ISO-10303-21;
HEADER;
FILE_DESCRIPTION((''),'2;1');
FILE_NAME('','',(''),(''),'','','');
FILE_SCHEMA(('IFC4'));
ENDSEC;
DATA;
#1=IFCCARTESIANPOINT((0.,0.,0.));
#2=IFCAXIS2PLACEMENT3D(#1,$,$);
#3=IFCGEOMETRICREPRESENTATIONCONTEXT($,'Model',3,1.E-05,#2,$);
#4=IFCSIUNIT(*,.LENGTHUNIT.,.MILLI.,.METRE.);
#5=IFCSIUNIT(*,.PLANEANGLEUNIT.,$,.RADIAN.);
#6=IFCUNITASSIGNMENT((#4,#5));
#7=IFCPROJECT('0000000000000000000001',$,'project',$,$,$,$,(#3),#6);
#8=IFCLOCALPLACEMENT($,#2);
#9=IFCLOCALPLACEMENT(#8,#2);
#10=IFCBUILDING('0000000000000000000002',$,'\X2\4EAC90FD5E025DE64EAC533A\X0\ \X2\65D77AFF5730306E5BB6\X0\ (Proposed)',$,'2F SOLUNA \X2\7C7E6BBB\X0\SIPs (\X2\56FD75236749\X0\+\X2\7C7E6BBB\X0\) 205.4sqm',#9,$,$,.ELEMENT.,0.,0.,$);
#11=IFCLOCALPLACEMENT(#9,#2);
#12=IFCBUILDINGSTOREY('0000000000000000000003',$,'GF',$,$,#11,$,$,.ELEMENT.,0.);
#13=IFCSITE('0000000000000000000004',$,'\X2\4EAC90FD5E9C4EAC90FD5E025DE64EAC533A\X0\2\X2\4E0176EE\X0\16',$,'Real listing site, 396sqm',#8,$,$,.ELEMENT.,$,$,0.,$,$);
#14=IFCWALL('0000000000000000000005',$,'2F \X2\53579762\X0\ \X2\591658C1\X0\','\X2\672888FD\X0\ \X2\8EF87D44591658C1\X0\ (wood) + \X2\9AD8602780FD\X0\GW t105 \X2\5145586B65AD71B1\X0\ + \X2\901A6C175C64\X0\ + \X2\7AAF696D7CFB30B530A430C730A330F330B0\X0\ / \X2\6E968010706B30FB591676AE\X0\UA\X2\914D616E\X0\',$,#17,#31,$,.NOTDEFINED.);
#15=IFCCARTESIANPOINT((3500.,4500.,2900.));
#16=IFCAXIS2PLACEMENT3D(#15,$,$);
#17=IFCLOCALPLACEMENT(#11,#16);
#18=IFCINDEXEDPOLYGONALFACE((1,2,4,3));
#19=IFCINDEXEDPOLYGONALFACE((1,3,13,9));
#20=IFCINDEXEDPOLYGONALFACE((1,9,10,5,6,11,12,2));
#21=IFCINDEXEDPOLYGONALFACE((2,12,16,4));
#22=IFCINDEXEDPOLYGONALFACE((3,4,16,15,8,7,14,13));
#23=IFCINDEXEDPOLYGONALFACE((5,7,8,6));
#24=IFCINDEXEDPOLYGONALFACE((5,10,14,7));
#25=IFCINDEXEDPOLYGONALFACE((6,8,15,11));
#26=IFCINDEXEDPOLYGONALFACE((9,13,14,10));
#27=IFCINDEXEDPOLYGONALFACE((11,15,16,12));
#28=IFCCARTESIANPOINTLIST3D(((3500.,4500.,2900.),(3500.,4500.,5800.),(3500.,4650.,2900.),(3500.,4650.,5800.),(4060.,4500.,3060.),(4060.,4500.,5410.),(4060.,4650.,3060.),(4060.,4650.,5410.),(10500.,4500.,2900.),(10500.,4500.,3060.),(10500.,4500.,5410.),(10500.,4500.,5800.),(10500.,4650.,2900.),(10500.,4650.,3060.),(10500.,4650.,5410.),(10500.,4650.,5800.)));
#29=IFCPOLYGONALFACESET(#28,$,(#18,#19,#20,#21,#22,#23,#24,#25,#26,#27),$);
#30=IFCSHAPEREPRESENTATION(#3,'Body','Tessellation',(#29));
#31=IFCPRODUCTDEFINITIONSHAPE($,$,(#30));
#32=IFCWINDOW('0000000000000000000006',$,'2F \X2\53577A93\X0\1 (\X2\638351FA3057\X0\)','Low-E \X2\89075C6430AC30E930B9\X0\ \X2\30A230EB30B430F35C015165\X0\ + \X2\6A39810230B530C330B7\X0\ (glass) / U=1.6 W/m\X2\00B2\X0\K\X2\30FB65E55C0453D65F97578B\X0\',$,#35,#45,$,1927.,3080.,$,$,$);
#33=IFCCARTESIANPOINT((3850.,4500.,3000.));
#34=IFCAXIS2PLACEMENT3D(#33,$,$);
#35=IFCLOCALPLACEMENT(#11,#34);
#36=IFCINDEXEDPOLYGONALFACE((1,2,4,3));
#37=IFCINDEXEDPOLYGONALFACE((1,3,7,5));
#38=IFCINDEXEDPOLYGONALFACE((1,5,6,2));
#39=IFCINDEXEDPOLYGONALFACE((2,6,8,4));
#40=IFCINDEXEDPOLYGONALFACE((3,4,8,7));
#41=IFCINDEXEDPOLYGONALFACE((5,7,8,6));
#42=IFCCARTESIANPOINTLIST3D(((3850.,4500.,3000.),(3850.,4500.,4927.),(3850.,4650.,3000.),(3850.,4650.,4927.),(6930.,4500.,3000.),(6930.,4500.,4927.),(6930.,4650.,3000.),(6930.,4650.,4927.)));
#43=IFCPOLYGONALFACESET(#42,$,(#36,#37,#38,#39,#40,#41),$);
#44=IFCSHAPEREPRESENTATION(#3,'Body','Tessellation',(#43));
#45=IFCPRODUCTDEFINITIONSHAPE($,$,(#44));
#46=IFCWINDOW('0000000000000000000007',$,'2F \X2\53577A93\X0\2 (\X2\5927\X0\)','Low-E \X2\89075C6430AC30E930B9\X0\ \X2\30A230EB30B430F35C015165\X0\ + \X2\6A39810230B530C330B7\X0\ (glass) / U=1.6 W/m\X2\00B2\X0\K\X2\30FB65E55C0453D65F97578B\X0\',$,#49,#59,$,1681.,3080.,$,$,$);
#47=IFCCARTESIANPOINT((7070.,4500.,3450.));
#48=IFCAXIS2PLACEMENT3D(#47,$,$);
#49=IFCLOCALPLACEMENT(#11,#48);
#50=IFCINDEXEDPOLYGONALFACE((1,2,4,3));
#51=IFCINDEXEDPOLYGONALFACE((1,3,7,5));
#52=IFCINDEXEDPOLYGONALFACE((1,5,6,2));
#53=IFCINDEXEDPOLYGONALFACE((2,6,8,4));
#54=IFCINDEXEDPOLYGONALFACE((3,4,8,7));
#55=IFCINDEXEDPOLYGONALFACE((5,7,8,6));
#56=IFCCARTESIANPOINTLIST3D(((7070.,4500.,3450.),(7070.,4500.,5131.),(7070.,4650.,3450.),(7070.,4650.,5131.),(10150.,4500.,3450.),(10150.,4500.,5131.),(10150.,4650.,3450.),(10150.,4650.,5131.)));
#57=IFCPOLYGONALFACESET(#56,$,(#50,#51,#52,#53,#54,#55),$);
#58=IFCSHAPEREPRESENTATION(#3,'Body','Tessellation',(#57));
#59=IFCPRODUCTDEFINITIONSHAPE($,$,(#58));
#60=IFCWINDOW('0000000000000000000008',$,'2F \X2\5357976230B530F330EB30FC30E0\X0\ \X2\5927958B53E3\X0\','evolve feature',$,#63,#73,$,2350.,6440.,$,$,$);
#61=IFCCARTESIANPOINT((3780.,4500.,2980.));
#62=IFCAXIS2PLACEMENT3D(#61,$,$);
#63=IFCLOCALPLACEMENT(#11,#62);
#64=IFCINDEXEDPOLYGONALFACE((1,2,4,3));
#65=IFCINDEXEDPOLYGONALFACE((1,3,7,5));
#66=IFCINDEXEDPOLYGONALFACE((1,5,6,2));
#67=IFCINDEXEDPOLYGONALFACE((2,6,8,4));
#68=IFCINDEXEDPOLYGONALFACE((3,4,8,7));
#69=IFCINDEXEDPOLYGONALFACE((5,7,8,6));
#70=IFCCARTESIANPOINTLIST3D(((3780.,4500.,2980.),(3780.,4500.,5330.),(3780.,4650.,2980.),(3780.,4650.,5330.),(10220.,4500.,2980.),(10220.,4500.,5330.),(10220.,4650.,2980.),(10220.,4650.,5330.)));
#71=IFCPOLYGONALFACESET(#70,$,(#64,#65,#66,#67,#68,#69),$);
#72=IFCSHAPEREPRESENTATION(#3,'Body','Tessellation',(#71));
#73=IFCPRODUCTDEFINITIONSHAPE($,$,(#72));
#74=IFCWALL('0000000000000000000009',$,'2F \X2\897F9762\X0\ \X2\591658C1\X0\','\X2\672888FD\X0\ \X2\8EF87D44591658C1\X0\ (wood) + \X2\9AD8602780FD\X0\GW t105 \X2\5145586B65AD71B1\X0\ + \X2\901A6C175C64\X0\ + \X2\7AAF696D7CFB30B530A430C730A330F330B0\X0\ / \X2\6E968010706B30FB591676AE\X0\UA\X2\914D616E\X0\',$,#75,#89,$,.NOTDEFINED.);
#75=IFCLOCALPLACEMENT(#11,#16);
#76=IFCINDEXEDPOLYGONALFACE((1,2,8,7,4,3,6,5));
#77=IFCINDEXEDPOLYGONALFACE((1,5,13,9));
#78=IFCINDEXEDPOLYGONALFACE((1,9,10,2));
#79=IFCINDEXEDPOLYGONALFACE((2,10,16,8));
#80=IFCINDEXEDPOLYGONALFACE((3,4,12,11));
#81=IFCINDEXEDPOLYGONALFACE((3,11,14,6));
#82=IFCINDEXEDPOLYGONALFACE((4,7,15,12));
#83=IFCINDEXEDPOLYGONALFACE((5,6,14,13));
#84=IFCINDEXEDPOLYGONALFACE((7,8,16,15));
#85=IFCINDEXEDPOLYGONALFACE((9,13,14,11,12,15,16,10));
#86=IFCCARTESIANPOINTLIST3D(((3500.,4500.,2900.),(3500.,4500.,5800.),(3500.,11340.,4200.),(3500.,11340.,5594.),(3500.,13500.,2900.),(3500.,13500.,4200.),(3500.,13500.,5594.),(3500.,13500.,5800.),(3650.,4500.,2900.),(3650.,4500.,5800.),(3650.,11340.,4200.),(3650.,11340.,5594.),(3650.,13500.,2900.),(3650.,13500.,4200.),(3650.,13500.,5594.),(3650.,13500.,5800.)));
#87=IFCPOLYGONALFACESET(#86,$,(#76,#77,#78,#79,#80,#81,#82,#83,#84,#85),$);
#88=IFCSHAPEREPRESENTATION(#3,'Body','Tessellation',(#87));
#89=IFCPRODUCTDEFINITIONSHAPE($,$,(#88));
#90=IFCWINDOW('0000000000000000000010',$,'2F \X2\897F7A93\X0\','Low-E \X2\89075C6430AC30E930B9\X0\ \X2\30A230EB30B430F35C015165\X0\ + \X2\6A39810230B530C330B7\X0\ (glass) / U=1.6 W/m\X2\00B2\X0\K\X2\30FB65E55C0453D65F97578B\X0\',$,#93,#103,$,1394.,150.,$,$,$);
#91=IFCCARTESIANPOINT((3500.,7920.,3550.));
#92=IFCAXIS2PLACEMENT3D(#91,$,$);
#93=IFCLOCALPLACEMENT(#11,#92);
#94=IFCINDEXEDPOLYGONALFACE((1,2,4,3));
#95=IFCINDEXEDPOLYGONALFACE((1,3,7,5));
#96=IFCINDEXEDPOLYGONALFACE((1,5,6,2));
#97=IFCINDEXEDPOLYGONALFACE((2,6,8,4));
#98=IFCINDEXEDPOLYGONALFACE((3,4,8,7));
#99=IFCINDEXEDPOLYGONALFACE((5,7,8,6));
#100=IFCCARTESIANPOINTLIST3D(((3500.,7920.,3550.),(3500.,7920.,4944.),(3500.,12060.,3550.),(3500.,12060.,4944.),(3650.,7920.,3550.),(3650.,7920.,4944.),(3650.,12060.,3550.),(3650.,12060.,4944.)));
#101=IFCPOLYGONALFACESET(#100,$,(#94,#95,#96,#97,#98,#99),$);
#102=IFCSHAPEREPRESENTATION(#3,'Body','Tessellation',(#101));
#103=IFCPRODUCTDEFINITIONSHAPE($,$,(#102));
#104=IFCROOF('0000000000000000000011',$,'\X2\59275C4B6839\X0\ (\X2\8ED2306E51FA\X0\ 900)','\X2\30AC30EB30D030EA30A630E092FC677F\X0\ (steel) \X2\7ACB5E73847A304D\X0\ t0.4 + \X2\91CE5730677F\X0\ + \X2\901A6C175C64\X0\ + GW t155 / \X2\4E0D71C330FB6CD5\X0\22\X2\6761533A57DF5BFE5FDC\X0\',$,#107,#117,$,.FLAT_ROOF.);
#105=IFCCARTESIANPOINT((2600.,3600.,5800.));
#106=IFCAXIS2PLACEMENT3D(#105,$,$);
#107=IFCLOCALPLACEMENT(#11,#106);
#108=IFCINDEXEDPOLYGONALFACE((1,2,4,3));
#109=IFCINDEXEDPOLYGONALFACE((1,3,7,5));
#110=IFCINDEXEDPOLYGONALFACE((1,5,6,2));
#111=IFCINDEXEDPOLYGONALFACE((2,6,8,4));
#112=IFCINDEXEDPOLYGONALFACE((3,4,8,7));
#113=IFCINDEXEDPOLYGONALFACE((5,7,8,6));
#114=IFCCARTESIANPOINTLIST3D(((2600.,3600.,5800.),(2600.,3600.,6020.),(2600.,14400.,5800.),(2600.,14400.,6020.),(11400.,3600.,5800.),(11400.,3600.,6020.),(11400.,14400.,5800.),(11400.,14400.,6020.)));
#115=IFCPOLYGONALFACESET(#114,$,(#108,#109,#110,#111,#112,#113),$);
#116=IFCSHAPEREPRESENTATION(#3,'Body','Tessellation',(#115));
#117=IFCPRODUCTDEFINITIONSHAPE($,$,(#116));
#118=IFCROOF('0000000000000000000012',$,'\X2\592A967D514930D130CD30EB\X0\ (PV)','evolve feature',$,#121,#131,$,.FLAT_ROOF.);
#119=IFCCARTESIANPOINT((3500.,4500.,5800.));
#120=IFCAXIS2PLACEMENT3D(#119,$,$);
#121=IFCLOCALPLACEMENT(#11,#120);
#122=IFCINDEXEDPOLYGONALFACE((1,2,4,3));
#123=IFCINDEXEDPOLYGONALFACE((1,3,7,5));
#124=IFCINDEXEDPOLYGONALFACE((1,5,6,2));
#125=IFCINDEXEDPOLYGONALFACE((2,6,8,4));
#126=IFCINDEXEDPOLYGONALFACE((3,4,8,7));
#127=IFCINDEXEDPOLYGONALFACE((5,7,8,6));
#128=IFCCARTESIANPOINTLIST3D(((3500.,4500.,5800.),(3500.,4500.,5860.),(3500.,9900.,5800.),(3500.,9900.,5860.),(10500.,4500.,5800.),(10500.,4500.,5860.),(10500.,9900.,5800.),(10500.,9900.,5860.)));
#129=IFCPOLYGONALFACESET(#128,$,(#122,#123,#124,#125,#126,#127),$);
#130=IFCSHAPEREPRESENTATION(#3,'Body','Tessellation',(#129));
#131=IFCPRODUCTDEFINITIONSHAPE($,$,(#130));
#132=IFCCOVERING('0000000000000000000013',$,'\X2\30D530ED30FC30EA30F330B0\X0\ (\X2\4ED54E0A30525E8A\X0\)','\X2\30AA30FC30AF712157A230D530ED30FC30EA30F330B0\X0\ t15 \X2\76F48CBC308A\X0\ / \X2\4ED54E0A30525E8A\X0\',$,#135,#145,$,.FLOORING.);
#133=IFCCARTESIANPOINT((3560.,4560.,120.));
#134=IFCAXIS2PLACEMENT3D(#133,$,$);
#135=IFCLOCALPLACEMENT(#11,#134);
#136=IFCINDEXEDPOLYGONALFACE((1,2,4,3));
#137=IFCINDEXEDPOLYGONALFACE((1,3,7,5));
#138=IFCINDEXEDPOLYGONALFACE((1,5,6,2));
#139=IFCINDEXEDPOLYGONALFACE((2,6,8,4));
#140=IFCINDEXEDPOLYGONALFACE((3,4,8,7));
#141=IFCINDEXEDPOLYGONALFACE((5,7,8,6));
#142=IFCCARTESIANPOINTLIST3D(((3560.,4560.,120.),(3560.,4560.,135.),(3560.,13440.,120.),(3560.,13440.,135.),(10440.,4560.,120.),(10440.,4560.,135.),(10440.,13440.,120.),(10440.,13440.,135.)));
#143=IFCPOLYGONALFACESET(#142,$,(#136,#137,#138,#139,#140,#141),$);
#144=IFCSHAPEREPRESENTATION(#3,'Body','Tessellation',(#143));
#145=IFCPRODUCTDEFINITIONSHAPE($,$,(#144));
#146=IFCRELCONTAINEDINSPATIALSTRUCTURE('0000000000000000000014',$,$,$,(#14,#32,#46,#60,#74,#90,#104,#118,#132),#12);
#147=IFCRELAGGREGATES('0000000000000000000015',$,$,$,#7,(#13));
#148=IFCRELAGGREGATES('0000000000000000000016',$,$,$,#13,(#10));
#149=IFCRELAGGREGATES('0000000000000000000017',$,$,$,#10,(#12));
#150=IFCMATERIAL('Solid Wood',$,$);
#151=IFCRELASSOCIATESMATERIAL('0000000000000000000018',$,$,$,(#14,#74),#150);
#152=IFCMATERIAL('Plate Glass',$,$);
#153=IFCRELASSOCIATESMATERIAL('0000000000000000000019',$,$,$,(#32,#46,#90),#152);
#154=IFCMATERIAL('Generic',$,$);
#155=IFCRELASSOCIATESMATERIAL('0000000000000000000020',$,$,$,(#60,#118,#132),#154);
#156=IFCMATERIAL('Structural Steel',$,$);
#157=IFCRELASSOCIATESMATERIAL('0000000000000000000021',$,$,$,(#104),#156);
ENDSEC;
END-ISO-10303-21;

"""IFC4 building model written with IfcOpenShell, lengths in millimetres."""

from ifc_helpers import new_model, si_unit, frame, frame_2d, origin, place, context, project, spatial, rectangle, extrude, material, element, fill, save


model = new_model("IFC4")

# Units and contexts
model_context = context("Model", 3, precision=1e-05, world=origin())
ifc_project = project(units=[si_unit("LENGTHUNIT", "METRE", prefix="MILLI"), si_unit("PLANEANGLEUNIT", "RADIAN")], contexts=[model_context])

# Site, building, storey
site_placement = place(None, origin())
site = spatial("IfcSite", under=ifc_project, at=site_placement, Name="京都府京都市左京区2丁目16", ObjectType="Real listing site, 396sqm", CompositionType="ELEMENT", RefElevation=0.0)
building_placement = place(site_placement, origin())
building = spatial("IfcBuilding", under=site, at=building_placement, Name="京都市左京区 旗竿地の家 (Proposed)", ObjectType="2F SOLUNA 籾殻SIPs (国産杉+籾殻) 205.4sqm", CompositionType="ELEMENT", ElevationOfRefHeight=0.0, ElevationOfTerrain=0.0)
storey_placement = place(building_placement, origin())
storey = spatial("IfcBuildingStorey", under=building, at=storey_placement, Name="GF", CompositionType="ELEMENT", Elevation=0.0)

# Shared definitions
ifc_material_1 = material(Name="Solid Wood")

# Shared definitions
ifc_material_2 = material(Name="Plate Glass")
ifc_material_3 = material(Name="Generic")

# Wall, openings, windows
wall_1_placement = place(storey_placement, frame((3500.0, 4500.0, 2900.0)))
wall_1 = element("IfcWall", 1, at=wall_1_placement, inside=storey, material=ifc_material_1, Name="2F 南面 外壁", Description="木製 軸組外壁 (wood) + 高性能GW t105 充填断熱 + 通気層 + 窯業系サイディング / 準耐火・外皮UA配慮", PredefinedType="NOTDEFINED", context=model_context, shape_type="SweptSolid", body=[
    extrude(rectangle(XDim=7000.0, YDim=150.0, at=frame_2d((3500.0, 75.0))), frame((3500.0, 4500.0, 2900.0)), (0.0, 0.0, 1.0), 2900.0),
])
opening_1_placement = place(storey_placement, frame((3850.0, 4500.0, 3000.0)))
opening_1 = element("IfcOpeningElement", 2, at=opening_1_placement, cuts=wall_1, PredefinedType="NOTDEFINED", context=model_context, shape_type="SweptSolid", body=[
    extrude(rectangle(XDim=3080.0, YDim=150.0, at=frame_2d((1540.0, 75.0))), frame((3850.0, 4500.0, 3000.0)), (0.0, 0.0, 1.0), 1927.0),
])
opening_2_placement = place(storey_placement, frame((7070.0, 4500.0, 3450.0)))
opening_2 = element("IfcOpeningElement", 3, at=opening_2_placement, cuts=wall_1, PredefinedType="NOTDEFINED", context=model_context, shape_type="SweptSolid", body=[
    extrude(rectangle(XDim=3080.0, YDim=150.0, at=frame_2d((1540.0, 75.0))), frame((7070.0, 4500.0, 3450.0)), (0.0, 0.0, 1.0), 1681.0),
])
opening_3_placement = place(storey_placement, frame((3780.0, 4500.0, 2980.0)))
opening_3 = element("IfcOpeningElement", 4, at=opening_3_placement, cuts=wall_1, PredefinedType="NOTDEFINED", context=model_context, shape_type="SweptSolid", body=[
    extrude(rectangle(XDim=6440.0, YDim=150.0, at=frame_2d((3220.0, 75.0))), frame((3780.0, 4500.0, 2980.0)), (0.0, 0.0, 1.0), 2350.0),
])
window_1_placement = place(storey_placement, frame((3850.0, 4500.0, 3000.0)))
window_1 = element("IfcWindow", 5, at=window_1_placement, inside=storey, material=ifc_material_2, Name="2F 南窓1 (掃出し)", Description="Low-E 複層ガラス アルゴン封入 + 樹脂サッシ (glass) / U=1.6 W/m²K・日射取得型", OverallHeight=1927.0, OverallWidth=3080.0, context=model_context, shape_type="SweptSolid", body=[
    extrude(rectangle(XDim=3080.0, YDim=150.0, at=frame_2d((1540.0, 75.0))), frame((3850.0, 4500.0, 3000.0)), (0.0, 0.0, 1.0), 1927.0),
])
fill(opening_1, window_1)
window_2_placement = place(storey_placement, frame((7070.0, 4500.0, 3450.0)))
window_2 = element("IfcWindow", 6, at=window_2_placement, inside=storey, material=ifc_material_2, Name="2F 南窓2 (大)", Description="Low-E 複層ガラス アルゴン封入 + 樹脂サッシ (glass) / U=1.6 W/m²K・日射取得型", OverallHeight=1681.0, OverallWidth=3080.0, context=model_context, shape_type="SweptSolid", body=[
    extrude(rectangle(XDim=3080.0, YDim=150.0, at=frame_2d((1540.0, 75.0))), frame((7070.0, 4500.0, 3450.0)), (0.0, 0.0, 1.0), 1681.0),
])
fill(opening_2, window_2)
window_3_placement = place(storey_placement, frame((3780.0, 4500.0, 2980.0)))
window_3 = element("IfcWindow", 7, at=window_3_placement, inside=storey, material=ifc_material_3, Name="2F 南面サンルーム 大開口", Description="evolve feature", OverallHeight=2350.0, OverallWidth=6440.0, context=model_context, shape_type="SweptSolid", body=[
    extrude(rectangle(XDim=6440.0, YDim=150.0, at=frame_2d((3220.0, 75.0))), frame((3780.0, 4500.0, 2980.0)), (0.0, 0.0, 1.0), 2350.0),
])
fill(opening_3, window_3)

# Wall, opening, window
wall_2_placement = place(storey_placement, frame((3500.0, 4500.0, 2900.0)))
wall_2 = element("IfcWall", 8, at=wall_2_placement, inside=storey, material=ifc_material_1, Name="2F 西面 外壁", Description="木製 軸組外壁 (wood) + 高性能GW t105 充填断熱 + 通気層 + 窯業系サイディング / 準耐火・外皮UA配慮", PredefinedType="NOTDEFINED", context=model_context, shape_type="SweptSolid", body=[
    extrude(rectangle(XDim=150.0, YDim=9000.0, at=frame_2d((75.0, 4500.0))), frame((3500.0, 4500.0, 2900.0)), (0.0, 0.0, 1.0), 2900.0),
])
opening_4_placement = place(storey_placement, frame((3500.0, 7920.0, 3550.0)))
opening_4 = element("IfcOpeningElement", 9, at=opening_4_placement, cuts=wall_2, PredefinedType="NOTDEFINED", context=model_context, shape_type="SweptSolid", body=[
    extrude(rectangle(XDim=150.0, YDim=4140.0, at=frame_2d((75.0, 2070.0))), frame((3500.0, 7920.0, 3550.0)), (0.0, 0.0, 1.0), 1394.0),
])
window_4_placement = place(storey_placement, frame((3500.0, 7920.0, 3550.0)))
window_4 = element("IfcWindow", 10, at=window_4_placement, inside=storey, material=ifc_material_2, Name="2F 西窓", Description="Low-E 複層ガラス アルゴン封入 + 樹脂サッシ (glass) / U=1.6 W/m²K・日射取得型", OverallHeight=1394.0, OverallWidth=150.0, context=model_context, shape_type="SweptSolid", body=[
    extrude(rectangle(XDim=150.0, YDim=4140.0, at=frame_2d((75.0, 2070.0))), frame((3500.0, 7920.0, 3550.0)), (0.0, 0.0, 1.0), 1394.0),
])
fill(opening_4, window_4)

# Roofs
ifc_material_4 = material(Name="Structural Steel")
roof_1_placement = place(storey_placement, frame((2600.0, 3600.0, 5800.0)))
element("IfcRoof", 11, at=roof_1_placement, inside=storey, material=ifc_material_4, Name="大屋根 (軒の出 900)", Description="ガルバリウム鋼板 (steel) 立平葺き t0.4 + 野地板 + 通気層 + GW t155 / 不燃・法22条区域対応", PredefinedType="FLAT_ROOF", context=model_context, shape_type="SweptSolid", body=[
    extrude(rectangle(XDim=8800.0, YDim=10800.0, at=frame_2d((4400.0, 5400.0))), frame((2600.0, 3600.0, 5800.0)), (0.0, 0.0, 1.0), 220.0),
])
roof_2_placement = place(storey_placement, frame((3500.0, 4500.0, 5800.0)))
element("IfcRoof", 12, at=roof_2_placement, inside=storey, material=ifc_material_3, Name="太陽光パネル (PV)", Description="evolve feature", PredefinedType="FLAT_ROOF", context=model_context, shape_type="SweptSolid", body=[
    extrude(rectangle(XDim=7000.0, YDim=5400.0, at=frame_2d((3500.0, 2700.0))), frame((3500.0, 4500.0, 5800.0)), (0.0, 0.0, 1.0), 60.0),
])

# Covering
covering_placement = place(storey_placement, frame((3560.0, 4560.0, 120.0)))
element("IfcCovering", 13, at=covering_placement, inside=storey, material=ifc_material_3, Name="フローリング (仕上げ床)", Description="オーク無垢フローリング t15 直貼り / 仕上げ床", PredefinedType="FLOORING", context=model_context, shape_type="SweptSolid", body=[
    extrude(rectangle(XDim=6880.0, YDim=8880.0, at=frame_2d((3440.0, 4440.0))), frame((3560.0, 4560.0, 120.0)), (0.0, 0.0, 1.0), 15.0),
])

save(model, "model.ifc")
